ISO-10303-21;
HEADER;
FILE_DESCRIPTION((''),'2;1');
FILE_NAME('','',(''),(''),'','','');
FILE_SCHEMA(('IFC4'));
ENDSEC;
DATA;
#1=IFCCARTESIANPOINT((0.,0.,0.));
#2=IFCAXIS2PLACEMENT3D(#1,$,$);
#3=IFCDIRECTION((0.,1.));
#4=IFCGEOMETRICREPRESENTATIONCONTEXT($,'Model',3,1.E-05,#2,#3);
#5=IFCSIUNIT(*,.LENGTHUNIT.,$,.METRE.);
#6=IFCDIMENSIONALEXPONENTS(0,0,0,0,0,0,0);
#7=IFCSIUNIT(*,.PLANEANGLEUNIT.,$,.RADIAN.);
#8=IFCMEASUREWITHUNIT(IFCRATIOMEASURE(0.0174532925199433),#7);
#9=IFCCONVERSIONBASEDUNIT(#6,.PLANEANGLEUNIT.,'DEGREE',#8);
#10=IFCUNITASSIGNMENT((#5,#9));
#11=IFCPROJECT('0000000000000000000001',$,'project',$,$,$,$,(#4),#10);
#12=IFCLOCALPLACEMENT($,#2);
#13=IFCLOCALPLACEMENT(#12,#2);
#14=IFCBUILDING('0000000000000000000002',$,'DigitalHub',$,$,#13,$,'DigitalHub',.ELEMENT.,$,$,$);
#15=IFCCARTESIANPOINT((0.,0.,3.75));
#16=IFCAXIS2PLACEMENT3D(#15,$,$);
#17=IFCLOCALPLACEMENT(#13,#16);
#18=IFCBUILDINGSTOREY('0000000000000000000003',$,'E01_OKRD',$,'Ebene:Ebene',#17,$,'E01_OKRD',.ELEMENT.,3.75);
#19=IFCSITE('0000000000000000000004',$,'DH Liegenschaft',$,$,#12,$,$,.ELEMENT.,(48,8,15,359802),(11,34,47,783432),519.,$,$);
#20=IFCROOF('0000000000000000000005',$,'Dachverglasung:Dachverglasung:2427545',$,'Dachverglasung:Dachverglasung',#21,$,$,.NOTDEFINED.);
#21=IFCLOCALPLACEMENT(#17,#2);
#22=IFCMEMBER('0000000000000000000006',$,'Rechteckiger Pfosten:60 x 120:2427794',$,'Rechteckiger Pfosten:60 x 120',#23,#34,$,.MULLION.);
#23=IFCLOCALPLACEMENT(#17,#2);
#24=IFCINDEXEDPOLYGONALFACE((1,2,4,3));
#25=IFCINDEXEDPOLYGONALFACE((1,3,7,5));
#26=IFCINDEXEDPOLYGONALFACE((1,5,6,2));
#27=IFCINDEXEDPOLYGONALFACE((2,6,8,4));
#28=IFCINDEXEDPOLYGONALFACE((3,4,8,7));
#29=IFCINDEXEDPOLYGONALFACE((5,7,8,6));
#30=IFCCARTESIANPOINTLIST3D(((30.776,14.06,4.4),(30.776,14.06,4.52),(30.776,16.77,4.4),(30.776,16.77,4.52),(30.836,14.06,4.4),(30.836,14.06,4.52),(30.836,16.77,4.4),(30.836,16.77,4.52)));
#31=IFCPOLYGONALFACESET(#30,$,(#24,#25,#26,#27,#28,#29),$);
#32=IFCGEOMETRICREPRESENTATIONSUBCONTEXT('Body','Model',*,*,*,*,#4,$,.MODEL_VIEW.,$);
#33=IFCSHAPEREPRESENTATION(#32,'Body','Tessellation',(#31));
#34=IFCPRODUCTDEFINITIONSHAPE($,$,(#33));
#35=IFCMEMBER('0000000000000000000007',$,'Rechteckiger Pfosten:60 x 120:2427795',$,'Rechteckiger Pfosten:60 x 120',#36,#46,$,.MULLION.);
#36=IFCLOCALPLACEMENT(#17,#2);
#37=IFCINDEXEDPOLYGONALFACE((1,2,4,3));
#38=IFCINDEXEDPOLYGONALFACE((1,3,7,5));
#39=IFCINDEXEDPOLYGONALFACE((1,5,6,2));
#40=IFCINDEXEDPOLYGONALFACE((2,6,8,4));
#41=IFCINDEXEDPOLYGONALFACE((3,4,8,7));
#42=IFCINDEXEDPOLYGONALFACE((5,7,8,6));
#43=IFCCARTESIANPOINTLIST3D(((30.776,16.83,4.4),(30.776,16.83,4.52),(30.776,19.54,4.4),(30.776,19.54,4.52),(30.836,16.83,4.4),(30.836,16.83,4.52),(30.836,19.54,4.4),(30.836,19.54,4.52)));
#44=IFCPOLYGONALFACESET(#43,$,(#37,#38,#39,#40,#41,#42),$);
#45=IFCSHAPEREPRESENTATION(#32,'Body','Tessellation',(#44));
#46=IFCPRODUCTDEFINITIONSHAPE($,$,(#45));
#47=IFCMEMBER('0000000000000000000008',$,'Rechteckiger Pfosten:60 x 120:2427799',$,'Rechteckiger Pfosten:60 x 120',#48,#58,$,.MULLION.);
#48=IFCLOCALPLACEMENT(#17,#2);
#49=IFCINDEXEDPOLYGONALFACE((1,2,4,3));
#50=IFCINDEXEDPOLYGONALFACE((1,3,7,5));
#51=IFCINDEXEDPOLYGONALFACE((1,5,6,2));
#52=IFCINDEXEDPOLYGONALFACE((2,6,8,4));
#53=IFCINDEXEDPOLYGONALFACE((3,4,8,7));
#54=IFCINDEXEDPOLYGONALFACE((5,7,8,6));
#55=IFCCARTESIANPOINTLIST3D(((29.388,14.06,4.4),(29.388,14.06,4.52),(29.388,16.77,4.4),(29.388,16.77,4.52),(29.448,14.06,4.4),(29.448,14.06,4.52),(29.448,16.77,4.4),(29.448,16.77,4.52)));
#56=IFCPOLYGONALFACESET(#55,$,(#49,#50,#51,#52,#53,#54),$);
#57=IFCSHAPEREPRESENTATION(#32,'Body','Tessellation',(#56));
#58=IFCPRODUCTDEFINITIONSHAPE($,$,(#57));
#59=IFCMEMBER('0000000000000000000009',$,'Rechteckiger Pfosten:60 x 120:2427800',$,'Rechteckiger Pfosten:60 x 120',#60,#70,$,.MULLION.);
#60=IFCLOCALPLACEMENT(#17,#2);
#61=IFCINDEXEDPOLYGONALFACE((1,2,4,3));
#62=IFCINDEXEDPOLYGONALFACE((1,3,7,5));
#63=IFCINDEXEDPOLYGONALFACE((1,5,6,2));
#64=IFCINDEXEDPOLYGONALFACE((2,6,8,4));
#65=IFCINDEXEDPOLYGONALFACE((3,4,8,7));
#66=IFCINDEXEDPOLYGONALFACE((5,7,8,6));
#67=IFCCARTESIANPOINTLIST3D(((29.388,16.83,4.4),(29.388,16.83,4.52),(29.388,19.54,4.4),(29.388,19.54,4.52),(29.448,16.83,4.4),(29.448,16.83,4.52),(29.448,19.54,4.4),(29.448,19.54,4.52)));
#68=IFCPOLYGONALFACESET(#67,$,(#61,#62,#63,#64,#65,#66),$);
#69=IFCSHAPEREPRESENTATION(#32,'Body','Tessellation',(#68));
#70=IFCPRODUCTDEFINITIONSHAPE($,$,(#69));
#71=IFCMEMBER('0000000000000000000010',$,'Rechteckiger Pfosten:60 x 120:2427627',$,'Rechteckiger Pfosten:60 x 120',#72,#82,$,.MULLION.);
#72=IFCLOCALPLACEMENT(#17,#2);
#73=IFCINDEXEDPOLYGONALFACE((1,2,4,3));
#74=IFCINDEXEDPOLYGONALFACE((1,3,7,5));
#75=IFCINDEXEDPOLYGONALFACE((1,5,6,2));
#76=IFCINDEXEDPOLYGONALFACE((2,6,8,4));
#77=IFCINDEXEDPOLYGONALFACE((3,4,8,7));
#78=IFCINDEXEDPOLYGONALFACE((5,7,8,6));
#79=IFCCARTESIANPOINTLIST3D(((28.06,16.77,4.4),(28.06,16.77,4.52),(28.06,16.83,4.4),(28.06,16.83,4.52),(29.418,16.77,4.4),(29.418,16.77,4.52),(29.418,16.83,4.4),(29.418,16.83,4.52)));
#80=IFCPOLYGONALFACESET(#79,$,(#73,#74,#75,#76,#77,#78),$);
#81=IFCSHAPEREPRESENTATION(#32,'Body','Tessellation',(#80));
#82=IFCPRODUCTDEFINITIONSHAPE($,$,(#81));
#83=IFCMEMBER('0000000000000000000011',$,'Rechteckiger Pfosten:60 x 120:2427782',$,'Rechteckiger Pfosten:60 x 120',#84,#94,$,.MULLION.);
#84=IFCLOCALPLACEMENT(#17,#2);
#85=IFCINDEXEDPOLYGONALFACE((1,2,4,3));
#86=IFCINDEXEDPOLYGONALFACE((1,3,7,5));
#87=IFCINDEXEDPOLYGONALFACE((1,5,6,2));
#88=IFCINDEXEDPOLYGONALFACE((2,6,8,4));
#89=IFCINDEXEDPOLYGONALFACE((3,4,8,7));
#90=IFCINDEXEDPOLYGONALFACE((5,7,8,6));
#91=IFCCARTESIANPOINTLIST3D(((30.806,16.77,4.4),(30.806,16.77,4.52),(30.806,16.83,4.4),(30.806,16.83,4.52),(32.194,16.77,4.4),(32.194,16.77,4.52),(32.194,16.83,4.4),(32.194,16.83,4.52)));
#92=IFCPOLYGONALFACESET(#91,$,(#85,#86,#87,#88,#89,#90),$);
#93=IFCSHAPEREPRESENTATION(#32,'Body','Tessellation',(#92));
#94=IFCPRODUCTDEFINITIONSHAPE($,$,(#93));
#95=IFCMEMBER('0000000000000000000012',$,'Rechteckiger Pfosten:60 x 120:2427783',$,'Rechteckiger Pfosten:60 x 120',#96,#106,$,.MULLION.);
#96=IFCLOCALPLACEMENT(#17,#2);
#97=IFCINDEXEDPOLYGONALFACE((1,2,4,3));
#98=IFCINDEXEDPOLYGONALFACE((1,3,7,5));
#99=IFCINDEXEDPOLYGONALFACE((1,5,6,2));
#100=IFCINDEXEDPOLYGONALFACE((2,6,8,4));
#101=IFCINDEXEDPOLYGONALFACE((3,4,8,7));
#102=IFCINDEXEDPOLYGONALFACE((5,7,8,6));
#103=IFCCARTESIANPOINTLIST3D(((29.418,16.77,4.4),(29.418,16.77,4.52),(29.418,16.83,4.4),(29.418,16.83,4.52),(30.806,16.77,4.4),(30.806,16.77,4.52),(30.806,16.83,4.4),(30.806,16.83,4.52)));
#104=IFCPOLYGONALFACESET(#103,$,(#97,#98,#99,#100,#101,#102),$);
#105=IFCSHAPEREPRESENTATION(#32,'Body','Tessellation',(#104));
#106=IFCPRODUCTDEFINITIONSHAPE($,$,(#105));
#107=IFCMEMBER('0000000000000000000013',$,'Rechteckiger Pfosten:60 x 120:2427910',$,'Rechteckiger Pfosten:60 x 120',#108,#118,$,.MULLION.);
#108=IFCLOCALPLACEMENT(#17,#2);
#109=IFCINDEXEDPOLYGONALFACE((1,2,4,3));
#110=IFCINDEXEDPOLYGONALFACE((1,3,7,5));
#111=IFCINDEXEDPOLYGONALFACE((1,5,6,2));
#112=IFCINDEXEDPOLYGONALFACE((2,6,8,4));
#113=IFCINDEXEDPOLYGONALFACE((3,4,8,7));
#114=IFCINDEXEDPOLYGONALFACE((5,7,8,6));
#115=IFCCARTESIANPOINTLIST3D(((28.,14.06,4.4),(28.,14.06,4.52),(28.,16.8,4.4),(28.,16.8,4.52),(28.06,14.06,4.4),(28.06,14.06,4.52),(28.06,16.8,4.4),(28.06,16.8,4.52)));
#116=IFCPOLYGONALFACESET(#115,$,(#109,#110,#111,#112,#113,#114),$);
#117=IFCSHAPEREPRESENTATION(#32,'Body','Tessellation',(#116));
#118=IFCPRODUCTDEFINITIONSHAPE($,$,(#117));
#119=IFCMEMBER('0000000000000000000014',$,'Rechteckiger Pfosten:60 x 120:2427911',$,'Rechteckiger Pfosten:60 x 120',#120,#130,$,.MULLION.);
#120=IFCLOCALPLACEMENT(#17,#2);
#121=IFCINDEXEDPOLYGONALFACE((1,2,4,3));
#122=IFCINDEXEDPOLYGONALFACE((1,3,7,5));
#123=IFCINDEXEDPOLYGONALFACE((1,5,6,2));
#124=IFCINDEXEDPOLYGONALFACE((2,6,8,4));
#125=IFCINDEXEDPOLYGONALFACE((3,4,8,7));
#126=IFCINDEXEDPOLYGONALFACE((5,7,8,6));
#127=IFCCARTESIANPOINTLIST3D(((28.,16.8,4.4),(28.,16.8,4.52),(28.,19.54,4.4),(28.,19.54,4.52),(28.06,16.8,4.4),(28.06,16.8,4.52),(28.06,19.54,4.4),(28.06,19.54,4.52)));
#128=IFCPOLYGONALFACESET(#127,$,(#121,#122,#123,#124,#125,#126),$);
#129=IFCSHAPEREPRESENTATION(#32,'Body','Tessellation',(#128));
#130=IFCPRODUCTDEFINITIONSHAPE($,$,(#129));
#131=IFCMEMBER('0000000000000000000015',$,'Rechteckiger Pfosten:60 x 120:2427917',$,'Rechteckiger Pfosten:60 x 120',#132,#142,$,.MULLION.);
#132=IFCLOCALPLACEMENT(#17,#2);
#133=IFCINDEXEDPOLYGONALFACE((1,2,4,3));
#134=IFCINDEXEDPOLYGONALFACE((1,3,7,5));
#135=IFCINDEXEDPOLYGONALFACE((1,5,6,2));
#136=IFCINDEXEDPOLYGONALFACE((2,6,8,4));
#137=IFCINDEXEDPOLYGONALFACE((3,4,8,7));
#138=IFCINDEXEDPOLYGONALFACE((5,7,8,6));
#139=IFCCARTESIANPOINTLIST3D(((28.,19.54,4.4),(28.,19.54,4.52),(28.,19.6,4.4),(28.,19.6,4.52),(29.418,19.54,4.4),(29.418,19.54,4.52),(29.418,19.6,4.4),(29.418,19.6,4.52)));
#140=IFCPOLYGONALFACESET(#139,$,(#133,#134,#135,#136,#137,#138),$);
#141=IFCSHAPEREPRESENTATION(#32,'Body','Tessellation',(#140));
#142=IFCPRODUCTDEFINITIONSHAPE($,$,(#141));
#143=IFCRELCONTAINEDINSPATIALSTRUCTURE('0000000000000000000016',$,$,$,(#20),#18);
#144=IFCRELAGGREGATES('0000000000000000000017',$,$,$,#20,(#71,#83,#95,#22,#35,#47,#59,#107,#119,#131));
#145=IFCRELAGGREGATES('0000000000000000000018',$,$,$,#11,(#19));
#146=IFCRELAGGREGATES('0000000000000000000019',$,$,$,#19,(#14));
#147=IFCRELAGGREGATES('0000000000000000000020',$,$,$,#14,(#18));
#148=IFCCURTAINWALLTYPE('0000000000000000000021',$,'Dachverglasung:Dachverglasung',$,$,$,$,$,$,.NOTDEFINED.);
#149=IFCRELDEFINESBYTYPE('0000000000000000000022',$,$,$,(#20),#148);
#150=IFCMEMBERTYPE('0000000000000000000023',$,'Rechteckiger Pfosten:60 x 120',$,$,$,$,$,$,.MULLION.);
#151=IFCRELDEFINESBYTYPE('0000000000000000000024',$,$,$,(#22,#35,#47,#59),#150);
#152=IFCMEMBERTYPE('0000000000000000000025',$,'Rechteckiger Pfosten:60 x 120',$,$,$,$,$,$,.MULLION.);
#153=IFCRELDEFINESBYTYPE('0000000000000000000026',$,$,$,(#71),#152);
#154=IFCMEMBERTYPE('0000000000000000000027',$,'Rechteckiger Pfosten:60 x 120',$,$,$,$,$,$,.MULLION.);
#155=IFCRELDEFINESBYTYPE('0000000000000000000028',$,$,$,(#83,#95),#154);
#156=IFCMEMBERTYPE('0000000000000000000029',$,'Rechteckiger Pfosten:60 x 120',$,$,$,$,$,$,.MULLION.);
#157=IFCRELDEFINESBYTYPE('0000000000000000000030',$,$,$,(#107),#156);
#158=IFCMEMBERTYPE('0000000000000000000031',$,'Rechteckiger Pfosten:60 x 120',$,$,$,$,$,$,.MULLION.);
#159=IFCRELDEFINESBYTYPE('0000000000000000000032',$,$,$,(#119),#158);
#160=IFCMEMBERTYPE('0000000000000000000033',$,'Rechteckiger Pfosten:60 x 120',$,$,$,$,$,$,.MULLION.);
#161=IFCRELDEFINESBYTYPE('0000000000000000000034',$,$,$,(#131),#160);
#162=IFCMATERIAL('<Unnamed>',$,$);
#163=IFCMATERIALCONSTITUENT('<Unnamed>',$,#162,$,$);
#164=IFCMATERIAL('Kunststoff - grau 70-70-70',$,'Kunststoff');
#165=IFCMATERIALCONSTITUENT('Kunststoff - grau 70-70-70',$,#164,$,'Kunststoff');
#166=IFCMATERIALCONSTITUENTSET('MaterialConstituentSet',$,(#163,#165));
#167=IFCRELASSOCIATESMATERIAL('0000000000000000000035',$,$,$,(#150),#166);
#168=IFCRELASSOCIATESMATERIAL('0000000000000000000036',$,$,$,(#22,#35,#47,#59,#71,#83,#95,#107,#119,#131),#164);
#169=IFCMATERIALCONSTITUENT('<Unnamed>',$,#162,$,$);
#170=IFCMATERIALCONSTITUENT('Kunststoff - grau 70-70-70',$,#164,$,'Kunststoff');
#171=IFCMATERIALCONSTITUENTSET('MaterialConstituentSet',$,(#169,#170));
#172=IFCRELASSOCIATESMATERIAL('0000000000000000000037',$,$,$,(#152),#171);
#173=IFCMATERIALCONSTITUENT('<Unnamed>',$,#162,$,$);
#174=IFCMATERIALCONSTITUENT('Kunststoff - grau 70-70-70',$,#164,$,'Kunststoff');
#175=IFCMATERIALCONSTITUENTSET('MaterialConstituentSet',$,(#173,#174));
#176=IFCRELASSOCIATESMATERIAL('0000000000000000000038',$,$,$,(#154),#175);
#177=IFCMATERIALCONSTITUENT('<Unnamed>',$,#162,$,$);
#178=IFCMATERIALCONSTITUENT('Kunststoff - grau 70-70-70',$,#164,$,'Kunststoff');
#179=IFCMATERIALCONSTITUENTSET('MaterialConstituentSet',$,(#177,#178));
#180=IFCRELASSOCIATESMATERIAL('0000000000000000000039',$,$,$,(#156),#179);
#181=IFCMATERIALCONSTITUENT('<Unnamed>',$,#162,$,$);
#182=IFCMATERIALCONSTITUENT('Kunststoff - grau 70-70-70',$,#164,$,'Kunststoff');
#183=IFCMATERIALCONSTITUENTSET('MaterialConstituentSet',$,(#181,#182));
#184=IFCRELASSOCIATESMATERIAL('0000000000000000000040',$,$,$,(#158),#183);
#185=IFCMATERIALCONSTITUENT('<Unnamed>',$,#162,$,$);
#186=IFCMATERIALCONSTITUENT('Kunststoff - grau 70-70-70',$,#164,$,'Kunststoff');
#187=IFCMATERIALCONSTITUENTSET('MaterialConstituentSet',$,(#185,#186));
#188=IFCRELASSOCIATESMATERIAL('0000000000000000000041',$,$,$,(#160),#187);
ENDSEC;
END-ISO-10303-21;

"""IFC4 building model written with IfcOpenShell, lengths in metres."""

from ifc_helpers import new_model, entity, si_unit, converted_unit, direction, frame, origin, place, context, subcontext, project, spatial, indexed_curve, outline, extrude, source, transform, mapped, material, constituent, constituent_set, type_object, type_shapes, element, aggregate, save


model = new_model("IFC4")

# Units and contexts
model_context = context("Model", 3, precision=1e-05, world=origin(), true_north=direction((0.0, 1.0)))
body_context = subcontext(model_context, "Body", "Model", "MODEL_VIEW")
ifc_project = project(units=[si_unit("LENGTHUNIT", "METRE"), converted_unit("PLANEANGLEUNIT", "DEGREE", entity("IfcRatioMeasure", 0.0174532925199433), si_unit("PLANEANGLEUNIT", "RADIAN"), dimensions=[0, 0, 0, 0, 0, 0, 0])], contexts=[model_context])

# Site, building, storey
site_placement = place(None, frame((0.0, 0.0, 0.0)))
site = spatial("IfcSite", under=ifc_project, at=site_placement, Name="DH Liegenschaft", CompositionType="ELEMENT", RefLatitude=(48, 8, 15, 359802), RefLongitude=(11, 34, 47, 783432), RefElevation=519.0)
building_placement = place(site_placement, origin())
building = spatial("IfcBuilding", under=site, at=building_placement, Name="DigitalHub", LongName="DigitalHub", CompositionType="ELEMENT")
storey_placement = place(building_placement, frame((0.0, 0.0, 3.75)))
storey = spatial("IfcBuildingStorey", under=building, at=storey_placement, Name="E01_OKRD", ObjectType="Ebene:Ebene", LongName="E01_OKRD", CompositionType="ELEMENT", Elevation=3.75)

# Roof, members
curtain_wall_type = type_object("IfcCurtainWallType", Name="Dachverglasung:Dachverglasung", PredefinedType="NOTDEFINED")
roof_placement = place(storey_placement, frame((0.0, 0.0, -3.75)))
roof = element("IfcRoof", 1, at=roof_placement, inside=storey, type_object=curtain_wall_type, Name="Dachverglasung:Dachverglasung:2427545", ObjectType="Dachverglasung:Dachverglasung", PredefinedType="NOTDEFINED")
ifc_material_1 = material(Name="Kunststoff - grau 70-70-70", Category="Kunststoff")
ifc_material_2 = material(Name="<Unnamed>")
ifc_constituent_1 = constituent(ifc_material_2, Name="<Unnamed>")
ifc_constituent_2 = constituent(ifc_material_1, Name="Kunststoff - grau 70-70-70", Category="Kunststoff")
ifc_constituent_set_1 = constituent_set(constituents=[ifc_constituent_1, ifc_constituent_2], Name="MaterialConstituentSet")
member_type_1 = type_object("IfcMemberType", Name="Rechteckiger Pfosten:60 x 120", PredefinedType="MULLION", material=ifc_constituent_set_1)
shared_shape_1 = source(origin(), body_context, "Body", "SweptSolid", [
    extrude(outline(indexed_curve([(-0.06, -0.03), (0.06, -0.03), (0.06, 0.03), (-0.06, 0.03), (-0.06, -0.03)], self_intersect=False)), frame((0.0, 0.0, -2.71), z_axis=(0.0, 0.0, 1.0), x_axis=(0.0, -1.0, 0.0)), (0.0, 0.0, 1.0), 2.71),
])
type_shapes(member_type_1, [shared_shape_1])
member_1_placement = place(storey_placement, frame((30.806, 14.06, 4.46), z_axis=(0.0, -1.0, 0.0), x_axis=(-1.0, 0.0, 0.0)))
member_1 = element("IfcMember", 2, at=member_1_placement, type_object=member_type_1, material=ifc_material_1, Name="Rechteckiger Pfosten:60 x 120:2427794", ObjectType="Rechteckiger Pfosten:60 x 120", PredefinedType="MULLION", context=body_context, shape_type="MappedRepresentation", body=[
    mapped(shared_shape_1, transform((0.0, 0.0, 0.0), scale=1.0)),
])
member_2_placement = place(storey_placement, frame((30.806, 16.83, 4.46), z_axis=(0.0, -1.0, 0.0), x_axis=(-1.0, 0.0, 0.0)))
member_2 = element("IfcMember", 3, at=member_2_placement, type_object=member_type_1, material=ifc_material_1, Name="Rechteckiger Pfosten:60 x 120:2427795", ObjectType="Rechteckiger Pfosten:60 x 120", PredefinedType="MULLION", context=body_context, shape_type="MappedRepresentation", body=[
    mapped(shared_shape_1, transform((0.0, 0.0, 0.0), scale=1.0)),
])
member_3_placement = place(storey_placement, frame((29.418, 14.06, 4.46), z_axis=(0.0, -1.0, 0.0), x_axis=(-1.0, 0.0, 0.0)))
member_3 = element("IfcMember", 4, at=member_3_placement, type_object=member_type_1, material=ifc_material_1, Name="Rechteckiger Pfosten:60 x 120:2427799", ObjectType="Rechteckiger Pfosten:60 x 120", PredefinedType="MULLION", context=body_context, shape_type="MappedRepresentation", body=[
    mapped(shared_shape_1, transform((0.0, 0.0, 0.0), scale=1.0)),
])
member_4_placement = place(storey_placement, frame((29.418, 16.83, 4.46), z_axis=(0.0, -1.0, 0.0), x_axis=(-1.0, 0.0, 0.0)))
member_4 = element("IfcMember", 5, at=member_4_placement, type_object=member_type_1, material=ifc_material_1, Name="Rechteckiger Pfosten:60 x 120:2427800", ObjectType="Rechteckiger Pfosten:60 x 120", PredefinedType="MULLION", context=body_context, shape_type="MappedRepresentation", body=[
    mapped(shared_shape_1, transform((0.0, 0.0, 0.0), scale=1.0)),
])
ifc_constituent_3 = constituent(ifc_material_2, Name="<Unnamed>")
ifc_constituent_4 = constituent(ifc_material_1, Name="Kunststoff - grau 70-70-70", Category="Kunststoff")
ifc_constituent_set_2 = constituent_set(constituents=[ifc_constituent_3, ifc_constituent_4], Name="MaterialConstituentSet")
member_type_2 = type_object("IfcMemberType", Name="Rechteckiger Pfosten:60 x 120", PredefinedType="MULLION", material=ifc_constituent_set_2)
shared_shape_2 = source(origin(), body_context, "Body", "SweptSolid", [
    extrude(outline(indexed_curve([(-0.06, -0.03), (0.06, -0.03), (0.06, 0.03), (-0.06, 0.03), (-0.06, -0.03)], self_intersect=False)), frame((0.0, 0.0, -1.358), z_axis=(0.0, 0.0, 1.0), x_axis=(0.0, -1.0, 0.0)), (0.0, 0.0, 1.0), 1.358),
])
type_shapes(member_type_2, [shared_shape_2])
member_5_placement = place(storey_placement, frame((28.06, 16.8, 4.46), z_axis=(-1.0, 0.0, 0.0), x_axis=(0.0, 1.0, 0.0)))
member_5 = element("IfcMember", 6, at=member_5_placement, type_object=member_type_2, material=ifc_material_1, Name="Rechteckiger Pfosten:60 x 120:2427627", ObjectType="Rechteckiger Pfosten:60 x 120", PredefinedType="MULLION", context=body_context, shape_type="MappedRepresentation", body=[
    mapped(shared_shape_2, transform((0.0, 0.0, 0.0), scale=1.0)),
])
ifc_constituent_5 = constituent(ifc_material_2, Name="<Unnamed>")
ifc_constituent_6 = constituent(ifc_material_1, Name="Kunststoff - grau 70-70-70", Category="Kunststoff")
ifc_constituent_set_3 = constituent_set(constituents=[ifc_constituent_5, ifc_constituent_6], Name="MaterialConstituentSet")
member_type_3 = type_object("IfcMemberType", Name="Rechteckiger Pfosten:60 x 120", PredefinedType="MULLION", material=ifc_constituent_set_3)
shared_shape_3 = source(origin(), body_context, "Body", "SweptSolid", [
    extrude(outline(indexed_curve([(-0.06, -0.03), (0.06, -0.03), (0.06, 0.03), (-0.06, 0.03), (-0.06, -0.03)], self_intersect=False)), frame((0.0, 0.0, -1.388), z_axis=(0.0, 0.0, 1.0), x_axis=(0.0, -1.0, 0.0)), (0.0, 0.0, 1.0), 1.388),
])
type_shapes(member_type_3, [shared_shape_3])
member_6_placement = place(storey_placement, frame((30.806, 16.8, 4.46), z_axis=(-1.0, 0.0, 0.0), x_axis=(0.0, 1.0, 0.0)))
member_6 = element("IfcMember", 7, at=member_6_placement, type_object=member_type_3, material=ifc_material_1, Name="Rechteckiger Pfosten:60 x 120:2427782", ObjectType="Rechteckiger Pfosten:60 x 120", PredefinedType="MULLION", context=body_context, shape_type="MappedRepresentation", body=[
    mapped(shared_shape_3, transform((0.0, 0.0, 0.0), scale=1.0)),
])
member_7_placement = place(storey_placement, frame((29.418, 16.8, 4.46), z_axis=(-1.0, 0.0, 0.0), x_axis=(0.0, 1.0, 0.0)))
member_7 = element("IfcMember", 8, at=member_7_placement, type_object=member_type_3, material=ifc_material_1, Name="Rechteckiger Pfosten:60 x 120:2427783", ObjectType="Rechteckiger Pfosten:60 x 120", PredefinedType="MULLION", context=body_context, shape_type="MappedRepresentation", body=[
    mapped(shared_shape_3, transform((0.0, 0.0, 0.0), scale=1.0)),
])
ifc_constituent_7 = constituent(ifc_material_2, Name="<Unnamed>")
ifc_constituent_8 = constituent(ifc_material_1, Name="Kunststoff - grau 70-70-70", Category="Kunststoff")
ifc_constituent_set_4 = constituent_set(constituents=[ifc_constituent_7, ifc_constituent_8], Name="MaterialConstituentSet")
member_type_4 = type_object("IfcMemberType", Name="Rechteckiger Pfosten:60 x 120", PredefinedType="MULLION", material=ifc_constituent_set_4)
shared_shape_4 = source(origin(), body_context, "Body", "SweptSolid", [
    extrude(outline(indexed_curve([(-0.06, -0.03), (0.06, -0.03), (0.06, 0.03), (-0.06, 0.03), (-0.06, -0.03)], self_intersect=False)), frame((-0.03, 0.0, -2.74), z_axis=(0.0, 0.0, 1.0), x_axis=(0.0, -1.0, 0.0)), (0.0, 0.0, 1.0), 2.74),
])
type_shapes(member_type_4, [shared_shape_4])
member_8_placement = place(storey_placement, frame((28.0, 14.06, 4.46), z_axis=(0.0, -1.0, 0.0), x_axis=(-1.0, 0.0, 0.0)))
member_8 = element("IfcMember", 9, at=member_8_placement, type_object=member_type_4, material=ifc_material_1, Name="Rechteckiger Pfosten:60 x 120:2427910", ObjectType="Rechteckiger Pfosten:60 x 120", PredefinedType="MULLION", context=body_context, shape_type="MappedRepresentation", body=[
    mapped(shared_shape_4, transform((0.0, 0.0, 0.0), scale=1.0)),
])
ifc_constituent_9 = constituent(ifc_material_2, Name="<Unnamed>")
ifc_constituent_10 = constituent(ifc_material_1, Name="Kunststoff - grau 70-70-70", Category="Kunststoff")
ifc_constituent_set_5 = constituent_set(constituents=[ifc_constituent_9, ifc_constituent_10], Name="MaterialConstituentSet")
member_type_5 = type_object("IfcMemberType", Name="Rechteckiger Pfosten:60 x 120", PredefinedType="MULLION", material=ifc_constituent_set_5)
shared_shape_5 = source(origin(), body_context, "Body", "SweptSolid", [
    extrude(outline(indexed_curve([(-0.06, -0.03), (0.06, -0.03), (0.06, 0.03), (-0.06, 0.03), (-0.06, -0.03)], self_intersect=False)), frame((-0.03, 0.0, -2.74), z_axis=(0.0, 0.0, 1.0), x_axis=(0.0, -1.0, 0.0)), (0.0, 0.0, 1.0), 2.74),
])
type_shapes(member_type_5, [shared_shape_5])
member_9_placement = place(storey_placement, frame((28.0, 16.8, 4.46), z_axis=(0.0, -1.0, 0.0), x_axis=(-1.0, 0.0, 0.0)))
member_9 = element("IfcMember", 10, at=member_9_placement, type_object=member_type_5, material=ifc_material_1, Name="Rechteckiger Pfosten:60 x 120:2427911", ObjectType="Rechteckiger Pfosten:60 x 120", PredefinedType="MULLION", context=body_context, shape_type="MappedRepresentation", body=[
    mapped(shared_shape_5, transform((0.0, 0.0, 0.0), scale=1.0)),
])
ifc_constituent_11 = constituent(ifc_material_2, Name="<Unnamed>")
ifc_constituent_12 = constituent(ifc_material_1, Name="Kunststoff - grau 70-70-70", Category="Kunststoff")
ifc_constituent_set_6 = constituent_set(constituents=[ifc_constituent_11, ifc_constituent_12], Name="MaterialConstituentSet")
member_type_6 = type_object("IfcMemberType", Name="Rechteckiger Pfosten:60 x 120", PredefinedType="MULLION", material=ifc_constituent_set_6)
shared_shape_6 = source(origin(), body_context, "Body", "SweptSolid", [
    extrude(outline(indexed_curve([(-0.06, -0.03), (0.06, -0.03), (0.06, 0.03), (-0.06, 0.03), (-0.06, -0.03)], self_intersect=False)), frame((-0.03, 0.0, -1.418), z_axis=(0.0, 0.0, 1.0), x_axis=(0.0, -1.0, 0.0)), (0.0, 0.0, 1.0), 1.418),
])
type_shapes(member_type_6, [shared_shape_6])
member_10_placement = place(storey_placement, frame((28.0, 19.6, 4.46), z_axis=(-1.0, 0.0, 0.0), x_axis=(0.0, 1.0, 0.0)))
member_10 = element("IfcMember", 11, at=member_10_placement, type_object=member_type_6, material=ifc_material_1, Name="Rechteckiger Pfosten:60 x 120:2427917", ObjectType="Rechteckiger Pfosten:60 x 120", PredefinedType="MULLION", context=body_context, shape_type="MappedRepresentation", body=[
    mapped(shared_shape_6, transform((0.0, 0.0, 0.0), scale=1.0)),
])
aggregate(roof, [member_5, member_6, member_7, member_1, member_2, member_3, member_4, member_8, member_9, member_10])

save(model, "model.ifc")
